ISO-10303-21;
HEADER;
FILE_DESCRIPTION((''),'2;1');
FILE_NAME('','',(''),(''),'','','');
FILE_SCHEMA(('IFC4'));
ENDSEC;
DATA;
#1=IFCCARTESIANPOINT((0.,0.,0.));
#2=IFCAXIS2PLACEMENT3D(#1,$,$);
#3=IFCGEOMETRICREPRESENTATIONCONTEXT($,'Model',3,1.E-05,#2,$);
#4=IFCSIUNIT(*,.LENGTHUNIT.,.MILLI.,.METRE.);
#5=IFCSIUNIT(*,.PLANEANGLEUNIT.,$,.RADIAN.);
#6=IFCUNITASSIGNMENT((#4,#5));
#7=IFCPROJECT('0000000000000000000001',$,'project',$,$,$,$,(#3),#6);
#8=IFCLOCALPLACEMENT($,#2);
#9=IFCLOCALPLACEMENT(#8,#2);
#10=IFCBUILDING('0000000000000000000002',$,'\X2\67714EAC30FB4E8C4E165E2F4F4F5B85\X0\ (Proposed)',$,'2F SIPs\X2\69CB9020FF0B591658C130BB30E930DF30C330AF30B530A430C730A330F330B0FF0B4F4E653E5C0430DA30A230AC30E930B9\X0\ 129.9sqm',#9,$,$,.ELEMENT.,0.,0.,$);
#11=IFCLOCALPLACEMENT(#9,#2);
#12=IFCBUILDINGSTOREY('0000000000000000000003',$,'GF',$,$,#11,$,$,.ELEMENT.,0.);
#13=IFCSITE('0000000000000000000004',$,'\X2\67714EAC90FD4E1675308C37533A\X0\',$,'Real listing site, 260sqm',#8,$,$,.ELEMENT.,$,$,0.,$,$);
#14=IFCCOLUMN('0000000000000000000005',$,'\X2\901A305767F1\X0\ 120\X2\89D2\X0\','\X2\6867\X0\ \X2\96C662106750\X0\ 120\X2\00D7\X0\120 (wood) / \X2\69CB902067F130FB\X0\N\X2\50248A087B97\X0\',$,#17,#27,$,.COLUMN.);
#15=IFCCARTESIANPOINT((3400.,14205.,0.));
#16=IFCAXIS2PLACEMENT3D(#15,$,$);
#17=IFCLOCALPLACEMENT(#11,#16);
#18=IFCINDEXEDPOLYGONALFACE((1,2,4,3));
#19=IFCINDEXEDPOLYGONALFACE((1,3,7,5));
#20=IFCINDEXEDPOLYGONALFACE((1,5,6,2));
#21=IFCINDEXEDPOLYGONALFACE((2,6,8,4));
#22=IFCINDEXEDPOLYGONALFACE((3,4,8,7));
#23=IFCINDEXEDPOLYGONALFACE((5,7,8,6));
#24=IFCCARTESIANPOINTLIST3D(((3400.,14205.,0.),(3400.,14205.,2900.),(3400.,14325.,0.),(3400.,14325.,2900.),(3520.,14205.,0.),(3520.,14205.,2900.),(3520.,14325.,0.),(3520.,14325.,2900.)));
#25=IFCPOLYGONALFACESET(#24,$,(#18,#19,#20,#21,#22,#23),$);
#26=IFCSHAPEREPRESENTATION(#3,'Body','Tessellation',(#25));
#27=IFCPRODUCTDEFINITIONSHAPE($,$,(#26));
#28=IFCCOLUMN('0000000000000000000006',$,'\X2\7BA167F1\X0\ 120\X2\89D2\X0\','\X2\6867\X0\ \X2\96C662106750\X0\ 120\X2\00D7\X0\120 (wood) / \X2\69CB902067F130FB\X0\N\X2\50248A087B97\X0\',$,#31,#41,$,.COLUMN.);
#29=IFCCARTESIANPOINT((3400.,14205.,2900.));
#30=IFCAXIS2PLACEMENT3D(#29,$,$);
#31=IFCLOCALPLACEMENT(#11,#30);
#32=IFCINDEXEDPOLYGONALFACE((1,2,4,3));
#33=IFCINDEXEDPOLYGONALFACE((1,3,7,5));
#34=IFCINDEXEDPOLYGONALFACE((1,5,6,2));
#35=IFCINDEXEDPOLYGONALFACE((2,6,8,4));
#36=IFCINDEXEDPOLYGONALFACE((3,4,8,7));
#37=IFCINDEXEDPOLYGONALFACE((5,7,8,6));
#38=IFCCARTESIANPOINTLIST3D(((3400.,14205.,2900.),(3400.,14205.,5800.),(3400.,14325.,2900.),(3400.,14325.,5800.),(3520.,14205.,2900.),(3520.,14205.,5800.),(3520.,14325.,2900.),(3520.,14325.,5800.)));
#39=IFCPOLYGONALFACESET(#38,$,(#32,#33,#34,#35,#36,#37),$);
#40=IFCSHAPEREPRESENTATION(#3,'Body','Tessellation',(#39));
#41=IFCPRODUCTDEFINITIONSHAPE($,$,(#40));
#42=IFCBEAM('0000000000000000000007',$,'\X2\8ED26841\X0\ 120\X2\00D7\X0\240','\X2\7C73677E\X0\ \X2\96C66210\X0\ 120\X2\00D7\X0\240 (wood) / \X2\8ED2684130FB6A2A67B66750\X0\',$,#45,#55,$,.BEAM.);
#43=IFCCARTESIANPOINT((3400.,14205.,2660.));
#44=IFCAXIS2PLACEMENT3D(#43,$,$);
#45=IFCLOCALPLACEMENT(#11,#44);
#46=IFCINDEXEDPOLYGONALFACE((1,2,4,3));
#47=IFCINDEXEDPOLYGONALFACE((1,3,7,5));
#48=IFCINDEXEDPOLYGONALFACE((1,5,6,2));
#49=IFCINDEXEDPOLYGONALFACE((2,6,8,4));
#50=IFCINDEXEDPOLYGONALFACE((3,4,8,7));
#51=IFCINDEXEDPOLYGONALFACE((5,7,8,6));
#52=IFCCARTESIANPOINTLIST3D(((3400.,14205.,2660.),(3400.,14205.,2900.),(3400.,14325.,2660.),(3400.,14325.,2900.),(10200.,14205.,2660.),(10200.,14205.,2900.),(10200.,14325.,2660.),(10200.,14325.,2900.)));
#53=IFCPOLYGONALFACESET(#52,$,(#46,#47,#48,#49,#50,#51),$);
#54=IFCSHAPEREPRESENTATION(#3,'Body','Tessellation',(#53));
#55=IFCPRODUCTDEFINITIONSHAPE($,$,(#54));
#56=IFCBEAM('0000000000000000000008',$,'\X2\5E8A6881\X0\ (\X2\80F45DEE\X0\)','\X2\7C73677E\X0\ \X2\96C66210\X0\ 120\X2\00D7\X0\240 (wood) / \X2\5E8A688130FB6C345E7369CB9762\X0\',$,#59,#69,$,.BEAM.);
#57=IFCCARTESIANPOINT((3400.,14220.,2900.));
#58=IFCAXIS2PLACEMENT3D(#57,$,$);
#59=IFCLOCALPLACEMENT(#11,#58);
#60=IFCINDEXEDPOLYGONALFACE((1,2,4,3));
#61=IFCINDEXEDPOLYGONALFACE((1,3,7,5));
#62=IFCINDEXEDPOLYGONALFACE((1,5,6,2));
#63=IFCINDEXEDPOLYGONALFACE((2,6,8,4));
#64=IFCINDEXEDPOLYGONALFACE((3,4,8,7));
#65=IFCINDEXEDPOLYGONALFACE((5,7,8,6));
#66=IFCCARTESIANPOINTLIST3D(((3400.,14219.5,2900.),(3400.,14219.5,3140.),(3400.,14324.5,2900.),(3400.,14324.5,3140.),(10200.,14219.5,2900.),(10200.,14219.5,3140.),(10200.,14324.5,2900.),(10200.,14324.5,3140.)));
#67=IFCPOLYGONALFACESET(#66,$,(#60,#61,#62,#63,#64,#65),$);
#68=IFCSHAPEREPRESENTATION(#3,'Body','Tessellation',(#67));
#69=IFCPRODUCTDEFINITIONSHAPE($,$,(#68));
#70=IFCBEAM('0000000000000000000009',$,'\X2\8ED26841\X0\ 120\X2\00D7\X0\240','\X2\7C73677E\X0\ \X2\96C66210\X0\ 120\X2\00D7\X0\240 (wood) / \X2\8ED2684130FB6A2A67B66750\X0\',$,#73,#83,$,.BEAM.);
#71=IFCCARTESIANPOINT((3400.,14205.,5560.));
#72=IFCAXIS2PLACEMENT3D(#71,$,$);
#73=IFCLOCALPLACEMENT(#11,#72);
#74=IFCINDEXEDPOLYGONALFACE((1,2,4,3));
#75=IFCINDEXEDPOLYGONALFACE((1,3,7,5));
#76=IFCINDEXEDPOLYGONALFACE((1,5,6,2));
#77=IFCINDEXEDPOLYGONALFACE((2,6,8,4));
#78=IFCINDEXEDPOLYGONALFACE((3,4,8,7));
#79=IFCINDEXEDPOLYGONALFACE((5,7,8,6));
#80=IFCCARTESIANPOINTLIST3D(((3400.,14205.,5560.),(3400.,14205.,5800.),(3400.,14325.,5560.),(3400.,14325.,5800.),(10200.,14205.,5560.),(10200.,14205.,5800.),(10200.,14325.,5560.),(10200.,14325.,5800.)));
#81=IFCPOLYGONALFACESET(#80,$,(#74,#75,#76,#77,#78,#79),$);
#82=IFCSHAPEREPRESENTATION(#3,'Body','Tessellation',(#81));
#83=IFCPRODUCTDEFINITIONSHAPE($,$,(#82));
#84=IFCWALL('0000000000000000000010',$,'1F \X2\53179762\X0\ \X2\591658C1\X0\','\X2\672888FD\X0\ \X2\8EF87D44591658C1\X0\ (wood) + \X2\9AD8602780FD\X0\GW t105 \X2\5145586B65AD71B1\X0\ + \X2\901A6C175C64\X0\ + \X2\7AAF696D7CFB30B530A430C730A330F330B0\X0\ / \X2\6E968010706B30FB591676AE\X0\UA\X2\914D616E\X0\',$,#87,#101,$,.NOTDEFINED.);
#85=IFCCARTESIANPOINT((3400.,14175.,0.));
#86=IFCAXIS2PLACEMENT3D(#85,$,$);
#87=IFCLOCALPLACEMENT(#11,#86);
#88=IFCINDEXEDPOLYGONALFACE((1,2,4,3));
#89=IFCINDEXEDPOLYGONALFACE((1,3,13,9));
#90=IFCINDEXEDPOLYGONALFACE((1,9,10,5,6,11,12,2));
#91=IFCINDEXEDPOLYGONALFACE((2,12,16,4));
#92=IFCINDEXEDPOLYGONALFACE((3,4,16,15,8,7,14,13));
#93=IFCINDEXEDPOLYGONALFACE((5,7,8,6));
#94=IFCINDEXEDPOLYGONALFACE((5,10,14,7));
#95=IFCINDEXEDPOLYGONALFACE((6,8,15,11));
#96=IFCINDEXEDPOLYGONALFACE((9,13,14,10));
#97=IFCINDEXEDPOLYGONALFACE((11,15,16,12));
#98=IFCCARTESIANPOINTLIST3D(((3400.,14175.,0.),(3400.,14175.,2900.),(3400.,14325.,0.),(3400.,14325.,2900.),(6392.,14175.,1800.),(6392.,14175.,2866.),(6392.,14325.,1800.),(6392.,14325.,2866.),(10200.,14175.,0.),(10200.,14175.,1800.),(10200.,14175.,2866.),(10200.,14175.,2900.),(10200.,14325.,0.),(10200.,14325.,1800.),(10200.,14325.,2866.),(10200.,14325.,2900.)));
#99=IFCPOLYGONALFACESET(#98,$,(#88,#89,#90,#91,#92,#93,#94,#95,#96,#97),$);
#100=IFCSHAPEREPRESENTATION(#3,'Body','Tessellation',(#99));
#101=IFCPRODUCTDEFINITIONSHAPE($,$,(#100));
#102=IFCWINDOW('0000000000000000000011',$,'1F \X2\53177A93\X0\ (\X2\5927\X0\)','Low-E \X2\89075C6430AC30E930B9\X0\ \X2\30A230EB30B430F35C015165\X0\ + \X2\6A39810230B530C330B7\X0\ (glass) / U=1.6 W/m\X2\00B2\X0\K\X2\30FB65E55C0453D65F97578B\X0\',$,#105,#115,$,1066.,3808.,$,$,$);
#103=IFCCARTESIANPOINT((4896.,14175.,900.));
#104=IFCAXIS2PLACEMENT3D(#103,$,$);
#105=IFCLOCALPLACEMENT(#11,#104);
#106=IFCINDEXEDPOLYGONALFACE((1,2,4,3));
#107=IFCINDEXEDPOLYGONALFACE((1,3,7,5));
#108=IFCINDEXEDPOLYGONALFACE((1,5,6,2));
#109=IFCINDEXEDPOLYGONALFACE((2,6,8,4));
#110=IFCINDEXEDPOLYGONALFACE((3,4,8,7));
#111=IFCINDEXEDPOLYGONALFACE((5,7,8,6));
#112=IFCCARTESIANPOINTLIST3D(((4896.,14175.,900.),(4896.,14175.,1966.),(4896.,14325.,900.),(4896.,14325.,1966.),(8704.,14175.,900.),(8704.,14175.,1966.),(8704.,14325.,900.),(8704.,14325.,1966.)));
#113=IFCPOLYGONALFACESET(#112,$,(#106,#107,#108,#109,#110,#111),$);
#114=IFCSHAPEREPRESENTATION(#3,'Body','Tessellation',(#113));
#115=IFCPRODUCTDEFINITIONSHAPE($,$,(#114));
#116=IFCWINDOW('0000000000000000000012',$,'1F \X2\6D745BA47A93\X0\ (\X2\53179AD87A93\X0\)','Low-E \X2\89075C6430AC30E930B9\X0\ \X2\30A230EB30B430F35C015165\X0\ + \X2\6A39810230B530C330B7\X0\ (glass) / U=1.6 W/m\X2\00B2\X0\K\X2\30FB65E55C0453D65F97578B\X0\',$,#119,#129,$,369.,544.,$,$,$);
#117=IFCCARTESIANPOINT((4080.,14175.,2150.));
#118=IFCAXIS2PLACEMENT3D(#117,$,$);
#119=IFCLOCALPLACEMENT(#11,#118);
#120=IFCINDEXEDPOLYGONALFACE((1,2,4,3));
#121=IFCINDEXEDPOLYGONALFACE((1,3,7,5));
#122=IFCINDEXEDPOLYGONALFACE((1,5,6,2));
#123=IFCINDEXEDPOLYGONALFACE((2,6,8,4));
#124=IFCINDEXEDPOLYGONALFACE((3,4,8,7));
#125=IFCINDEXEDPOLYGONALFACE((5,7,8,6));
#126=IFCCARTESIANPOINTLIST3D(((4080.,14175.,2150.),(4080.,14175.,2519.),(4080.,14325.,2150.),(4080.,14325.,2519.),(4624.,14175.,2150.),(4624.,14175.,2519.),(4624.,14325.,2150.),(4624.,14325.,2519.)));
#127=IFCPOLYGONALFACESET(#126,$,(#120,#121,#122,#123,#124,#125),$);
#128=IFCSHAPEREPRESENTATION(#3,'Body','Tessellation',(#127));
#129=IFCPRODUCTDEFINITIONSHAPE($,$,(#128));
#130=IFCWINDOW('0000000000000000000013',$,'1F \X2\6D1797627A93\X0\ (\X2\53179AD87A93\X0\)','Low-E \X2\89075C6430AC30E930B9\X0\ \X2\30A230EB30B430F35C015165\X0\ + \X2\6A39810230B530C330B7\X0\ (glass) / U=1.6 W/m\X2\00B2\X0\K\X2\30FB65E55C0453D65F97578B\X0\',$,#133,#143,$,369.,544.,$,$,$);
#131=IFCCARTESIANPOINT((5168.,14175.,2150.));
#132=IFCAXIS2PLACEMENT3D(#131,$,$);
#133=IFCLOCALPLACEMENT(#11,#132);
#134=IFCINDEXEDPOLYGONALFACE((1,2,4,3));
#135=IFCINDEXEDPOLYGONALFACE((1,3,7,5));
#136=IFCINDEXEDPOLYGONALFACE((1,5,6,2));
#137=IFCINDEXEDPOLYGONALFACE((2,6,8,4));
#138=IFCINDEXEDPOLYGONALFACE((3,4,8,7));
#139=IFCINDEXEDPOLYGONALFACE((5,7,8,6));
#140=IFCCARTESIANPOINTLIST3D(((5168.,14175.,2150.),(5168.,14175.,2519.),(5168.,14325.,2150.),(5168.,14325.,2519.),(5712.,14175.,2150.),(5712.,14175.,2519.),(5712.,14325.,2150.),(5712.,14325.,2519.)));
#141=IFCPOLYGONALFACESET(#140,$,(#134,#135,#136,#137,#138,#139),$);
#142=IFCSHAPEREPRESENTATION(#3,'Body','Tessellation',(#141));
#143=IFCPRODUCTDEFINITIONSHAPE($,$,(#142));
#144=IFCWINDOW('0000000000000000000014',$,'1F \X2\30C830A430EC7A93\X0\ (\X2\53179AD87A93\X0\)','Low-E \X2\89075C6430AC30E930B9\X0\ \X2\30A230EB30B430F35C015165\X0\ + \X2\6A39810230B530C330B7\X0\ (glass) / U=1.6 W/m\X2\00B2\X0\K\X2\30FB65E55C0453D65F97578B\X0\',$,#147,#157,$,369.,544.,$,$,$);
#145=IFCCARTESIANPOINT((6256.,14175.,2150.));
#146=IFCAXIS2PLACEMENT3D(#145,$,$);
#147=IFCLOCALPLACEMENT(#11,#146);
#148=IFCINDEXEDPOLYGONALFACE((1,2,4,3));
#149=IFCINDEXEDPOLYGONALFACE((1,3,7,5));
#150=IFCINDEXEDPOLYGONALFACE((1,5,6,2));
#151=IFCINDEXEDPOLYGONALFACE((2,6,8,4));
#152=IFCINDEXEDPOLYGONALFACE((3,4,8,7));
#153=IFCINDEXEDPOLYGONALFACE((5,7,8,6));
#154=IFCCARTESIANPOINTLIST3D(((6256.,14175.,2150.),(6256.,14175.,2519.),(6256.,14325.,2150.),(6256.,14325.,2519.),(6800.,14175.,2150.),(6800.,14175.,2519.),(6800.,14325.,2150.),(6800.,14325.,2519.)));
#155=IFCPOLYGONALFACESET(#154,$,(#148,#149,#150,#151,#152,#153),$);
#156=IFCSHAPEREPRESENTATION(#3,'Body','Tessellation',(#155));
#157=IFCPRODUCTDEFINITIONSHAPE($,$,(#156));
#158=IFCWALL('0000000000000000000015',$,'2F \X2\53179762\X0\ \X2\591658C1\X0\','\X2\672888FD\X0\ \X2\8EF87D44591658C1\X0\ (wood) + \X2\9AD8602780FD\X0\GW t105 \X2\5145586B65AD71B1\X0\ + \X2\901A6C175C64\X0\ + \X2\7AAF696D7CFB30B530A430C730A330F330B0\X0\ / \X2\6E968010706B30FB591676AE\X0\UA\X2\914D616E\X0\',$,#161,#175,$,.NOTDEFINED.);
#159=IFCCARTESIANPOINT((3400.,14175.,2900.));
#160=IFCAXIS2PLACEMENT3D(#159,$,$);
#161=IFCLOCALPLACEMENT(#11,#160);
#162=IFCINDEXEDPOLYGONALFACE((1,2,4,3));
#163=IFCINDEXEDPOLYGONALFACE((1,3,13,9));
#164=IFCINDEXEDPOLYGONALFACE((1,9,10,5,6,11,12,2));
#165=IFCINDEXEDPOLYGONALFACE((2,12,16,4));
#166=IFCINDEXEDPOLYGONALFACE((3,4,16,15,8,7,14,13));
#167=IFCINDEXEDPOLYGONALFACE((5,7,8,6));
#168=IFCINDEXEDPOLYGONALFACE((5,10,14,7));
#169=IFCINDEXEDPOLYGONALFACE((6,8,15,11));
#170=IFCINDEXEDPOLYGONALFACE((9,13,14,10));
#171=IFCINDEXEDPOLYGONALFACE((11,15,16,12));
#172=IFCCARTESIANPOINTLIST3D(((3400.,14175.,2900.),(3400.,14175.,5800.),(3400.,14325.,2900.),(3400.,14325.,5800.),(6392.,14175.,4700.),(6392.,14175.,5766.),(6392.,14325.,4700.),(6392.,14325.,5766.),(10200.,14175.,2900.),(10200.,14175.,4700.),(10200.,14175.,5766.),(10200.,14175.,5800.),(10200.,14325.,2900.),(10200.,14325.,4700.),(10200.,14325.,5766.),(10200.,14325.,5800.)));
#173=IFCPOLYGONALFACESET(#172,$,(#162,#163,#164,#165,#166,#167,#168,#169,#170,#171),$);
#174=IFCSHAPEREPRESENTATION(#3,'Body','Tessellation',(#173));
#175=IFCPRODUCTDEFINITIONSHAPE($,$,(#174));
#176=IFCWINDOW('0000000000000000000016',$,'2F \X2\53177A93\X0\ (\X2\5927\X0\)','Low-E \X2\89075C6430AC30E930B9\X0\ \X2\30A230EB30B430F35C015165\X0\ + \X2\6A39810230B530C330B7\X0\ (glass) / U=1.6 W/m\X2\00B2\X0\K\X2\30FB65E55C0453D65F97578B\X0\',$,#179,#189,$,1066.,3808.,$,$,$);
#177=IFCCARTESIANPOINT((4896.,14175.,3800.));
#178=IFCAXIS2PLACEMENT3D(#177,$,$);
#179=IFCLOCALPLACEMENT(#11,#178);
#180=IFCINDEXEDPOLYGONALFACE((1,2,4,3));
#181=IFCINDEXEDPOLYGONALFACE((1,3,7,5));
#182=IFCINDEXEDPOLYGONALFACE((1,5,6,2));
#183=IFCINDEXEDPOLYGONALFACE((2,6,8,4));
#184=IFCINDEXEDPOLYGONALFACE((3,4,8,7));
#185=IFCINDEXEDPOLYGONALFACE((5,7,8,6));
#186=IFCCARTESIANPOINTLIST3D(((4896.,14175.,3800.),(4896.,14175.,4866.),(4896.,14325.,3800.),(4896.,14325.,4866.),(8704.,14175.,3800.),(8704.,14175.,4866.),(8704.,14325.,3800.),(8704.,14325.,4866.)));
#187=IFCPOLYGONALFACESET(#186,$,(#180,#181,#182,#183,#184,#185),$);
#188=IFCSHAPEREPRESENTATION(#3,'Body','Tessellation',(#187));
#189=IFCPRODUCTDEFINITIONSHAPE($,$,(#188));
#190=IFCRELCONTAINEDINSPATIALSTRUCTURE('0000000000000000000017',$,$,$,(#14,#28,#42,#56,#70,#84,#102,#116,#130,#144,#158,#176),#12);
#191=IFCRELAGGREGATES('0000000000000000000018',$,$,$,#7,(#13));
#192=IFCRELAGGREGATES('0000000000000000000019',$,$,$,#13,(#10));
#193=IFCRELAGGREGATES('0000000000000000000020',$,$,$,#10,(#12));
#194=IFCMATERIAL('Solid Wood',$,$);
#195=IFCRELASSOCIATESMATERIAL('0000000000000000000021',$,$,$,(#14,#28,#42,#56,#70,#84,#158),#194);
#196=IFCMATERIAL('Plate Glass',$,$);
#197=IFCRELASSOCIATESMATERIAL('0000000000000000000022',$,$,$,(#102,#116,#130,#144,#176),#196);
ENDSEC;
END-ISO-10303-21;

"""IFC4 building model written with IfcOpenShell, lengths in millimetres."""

from ifc_helpers import new_model, si_unit, frame, frame_2d, origin, place, context, project, spatial, rectangle, extrude, material, element, fill, save


model = new_model("IFC4")

# Units and contexts
model_context = context("Model", 3, precision=1e-05, world=origin())
ifc_project = project(units=[si_unit("LENGTHUNIT", "METRE", prefix="MILLI"), si_unit("PLANEANGLEUNIT", "RADIAN")], contexts=[model_context])

# Site, building, storey
site_placement = place(None, origin())
site = spatial("IfcSite", under=ifc_project, at=site_placement, Name="東京都世田谷区", ObjectType="Real listing site, 260sqm", CompositionType="ELEMENT", RefElevation=0.0)
building_placement = place(site_placement, origin())
building = spatial("IfcBuilding", under=site, at=building_placement, Name="東京・二世帯住宅 (Proposed)", ObjectType="2F SIPs構造＋外壁セラミックサイディング＋低放射ペアガラス 129.9sqm", CompositionType="ELEMENT", ElevationOfRefHeight=0.0, ElevationOfTerrain=0.0)
storey_placement = place(building_placement, origin())
storey = spatial("IfcBuildingStorey", under=building, at=storey_placement, Name="GF", CompositionType="ELEMENT", Elevation=0.0)

# Columns
ifc_material_1 = material(Name="Solid Wood")
column_1_placement = place(storey_placement, frame((3400.0, 14205.0, 0.0)))
element("IfcColumn", 1, at=column_1_placement, inside=storey, material=ifc_material_1, Name="通し柱 120角", Description="桧 集成材 120×120 (wood) / 構造柱・N値計算", PredefinedType="COLUMN", context=model_context, shape_type="SweptSolid", body=[
    extrude(rectangle(XDim=120.0, YDim=120.0, at=frame_2d((60.0, 60.0))), frame((3400.0, 14205.0, 0.0)), (0.0, 0.0, 1.0), 2900.0),
])
column_2_placement = place(storey_placement, frame((3400.0, 14205.0, 2900.0)))
element("IfcColumn", 2, at=column_2_placement, inside=storey, material=ifc_material_1, Name="管柱 120角", Description="桧 集成材 120×120 (wood) / 構造柱・N値計算", PredefinedType="COLUMN", context=model_context, shape_type="SweptSolid", body=[
    extrude(rectangle(XDim=120.0, YDim=120.0, at=frame_2d((60.0, 60.0))), frame((3400.0, 14205.0, 2900.0)), (0.0, 0.0, 1.0), 2900.0),
])

# Beams
beam_1_placement = place(storey_placement, frame((3400.0, 14205.0, 2660.0)))
element("IfcBeam", 3, at=beam_1_placement, inside=storey, material=ifc_material_1, Name="軒桁 120×240", Description="米松 集成 120×240 (wood) / 軒桁・横架材", PredefinedType="BEAM", context=model_context, shape_type="SweptSolid", body=[
    extrude(rectangle(XDim=6800.0, YDim=120.0, at=frame_2d((3400.0, 60.0))), frame((3400.0, 14205.0, 2660.0)), (0.0, 0.0, 1.0), 240.0),
])
beam_2_placement = place(storey_placement, frame((3400.0, 14220.0, 2900.0)))
element("IfcBeam", 4, at=beam_2_placement, inside=storey, material=ifc_material_1, Name="床梁 (胴差)", Description="米松 集成 120×240 (wood) / 床梁・水平構面", PredefinedType="BEAM", context=model_context, shape_type="SweptSolid", body=[
    extrude(rectangle(XDim=6800.0, YDim=105.0, at=frame_2d((3400.0, 52.0))), frame((3400.0, 14220.0, 2900.0)), (0.0, 0.0, 1.0), 240.0),
])
beam_3_placement = place(storey_placement, frame((3400.0, 14205.0, 5560.0)))
element("IfcBeam", 5, at=beam_3_placement, inside=storey, material=ifc_material_1, Name="軒桁 120×240", Description="米松 集成 120×240 (wood) / 軒桁・横架材", PredefinedType="BEAM", context=model_context, shape_type="SweptSolid", body=[
    extrude(rectangle(XDim=6800.0, YDim=120.0, at=frame_2d((3400.0, 60.0))), frame((3400.0, 14205.0, 5560.0)), (0.0, 0.0, 1.0), 240.0),
])

# Wall, openings, windows
wall_1_placement = place(storey_placement, frame((3400.0, 14175.0, 0.0)))
wall_1 = element("IfcWall", 6, at=wall_1_placement, inside=storey, material=ifc_material_1, Name="1F 北面 外壁", Description="木製 軸組外壁 (wood) + 高性能GW t105 充填断熱 + 通気層 + 窯業系サイディング / 準耐火・外皮UA配慮", PredefinedType="NOTDEFINED", context=model_context, shape_type="SweptSolid", body=[
    extrude(rectangle(XDim=6800.0, YDim=150.0, at=frame_2d((3400.0, 75.0))), frame((3400.0, 14175.0, 0.0)), (0.0, 0.0, 1.0), 2900.0),
])
opening_1_placement = place(storey_placement, frame((4896.0, 14175.0, 900.0)))
opening_1 = element("IfcOpeningElement", 7, at=opening_1_placement, cuts=wall_1, PredefinedType="NOTDEFINED", context=model_context, shape_type="SweptSolid", body=[
    extrude(rectangle(XDim=3808.0, YDim=150.0, at=frame_2d((1904.0, 75.0))), frame((4896.0, 14175.0, 900.0)), (0.0, 0.0, 1.0), 1066.0),
])
opening_2_placement = place(storey_placement, frame((4080.0, 14175.0, 2150.0)))
opening_2 = element("IfcOpeningElement", 8, at=opening_2_placement, cuts=wall_1, PredefinedType="NOTDEFINED", context=model_context, shape_type="SweptSolid", body=[
    extrude(rectangle(XDim=544.0, YDim=150.0, at=frame_2d((272.0, 75.0))), frame((4080.0, 14175.0, 2150.0)), (0.0, 0.0, 1.0), 369.0),
])
opening_3_placement = place(storey_placement, frame((5168.0, 14175.0, 2150.0)))
opening_3 = element("IfcOpeningElement", 9, at=opening_3_placement, cuts=wall_1, PredefinedType="NOTDEFINED", context=model_context, shape_type="SweptSolid", body=[
    extrude(rectangle(XDim=544.0, YDim=150.0, at=frame_2d((272.0, 75.0))), frame((5168.0, 14175.0, 2150.0)), (0.0, 0.0, 1.0), 369.0),
])
opening_4_placement = place(storey_placement, frame((6256.0, 14175.0, 2150.0)))
opening_4 = element("IfcOpeningElement", 10, at=opening_4_placement, cuts=wall_1, PredefinedType="NOTDEFINED", context=model_context, shape_type="SweptSolid", body=[
    extrude(rectangle(XDim=544.0, YDim=150.0, at=frame_2d((272.0, 75.0))), frame((6256.0, 14175.0, 2150.0)), (0.0, 0.0, 1.0), 369.0),
])
ifc_material_2 = material(Name="Plate Glass")
window_1_placement = place(storey_placement, frame((4896.0, 14175.0, 900.0)))
window_1 = element("IfcWindow", 11, at=window_1_placement, inside=storey, material=ifc_material_2, Name="1F 北窓 (大)", Description="Low-E 複層ガラス アルゴン封入 + 樹脂サッシ (glass) / U=1.6 W/m²K・日射取得型", OverallHeight=1066.0, OverallWidth=3808.0, context=model_context, shape_type="SweptSolid", body=[
    extrude(rectangle(XDim=3808.0, YDim=150.0, at=frame_2d((1904.0, 75.0))), frame((4896.0, 14175.0, 900.0)), (0.0, 0.0, 1.0), 1066.0),
])
fill(opening_1, window_1)
window_2_placement = place(storey_placement, frame((4080.0, 14175.0, 2150.0)))
window_2 = element("IfcWindow", 12, at=window_2_placement, inside=storey, material=ifc_material_2, Name="1F 浴室窓 (北高窓)", Description="Low-E 複層ガラス アルゴン封入 + 樹脂サッシ (glass) / U=1.6 W/m²K・日射取得型", OverallHeight=369.0, OverallWidth=544.0, context=model_context, shape_type="SweptSolid", body=[
    extrude(rectangle(XDim=544.0, YDim=150.0, at=frame_2d((272.0, 75.0))), frame((4080.0, 14175.0, 2150.0)), (0.0, 0.0, 1.0), 369.0),
])
fill(opening_2, window_2)
window_3_placement = place(storey_placement, frame((5168.0, 14175.0, 2150.0)))
window_3 = element("IfcWindow", 13, at=window_3_placement, inside=storey, material=ifc_material_2, Name="1F 洗面窓 (北高窓)", Description="Low-E 複層ガラス アルゴン封入 + 樹脂サッシ (glass) / U=1.6 W/m²K・日射取得型", OverallHeight=369.0, OverallWidth=544.0, context=model_context, shape_type="SweptSolid", body=[
    extrude(rectangle(XDim=544.0, YDim=150.0, at=frame_2d((272.0, 75.0))), frame((5168.0, 14175.0, 2150.0)), (0.0, 0.0, 1.0), 369.0),
])
fill(opening_3, window_3)
window_4_placement = place(storey_placement, frame((6256.0, 14175.0, 2150.0)))
window_4 = element("IfcWindow", 14, at=window_4_placement, inside=storey, material=ifc_material_2, Name="1F トイレ窓 (北高窓)", Description="Low-E 複層ガラス アルゴン封入 + 樹脂サッシ (glass) / U=1.6 W/m²K・日射取得型", OverallHeight=369.0, OverallWidth=544.0, context=model_context, shape_type="SweptSolid", body=[
    extrude(rectangle(XDim=544.0, YDim=150.0, at=frame_2d((272.0, 75.0))), frame((6256.0, 14175.0, 2150.0)), (0.0, 0.0, 1.0), 369.0),
])
fill(opening_4, window_4)

# Wall, opening, window
wall_2_placement = place(storey_placement, frame((3400.0, 14175.0, 2900.0)))
wall_2 = element("IfcWall", 15, at=wall_2_placement, inside=storey, material=ifc_material_1, Name="2F 北面 外壁", Description="木製 軸組外壁 (wood) + 高性能GW t105 充填断熱 + 通気層 + 窯業系サイディング / 準耐火・外皮UA配慮", PredefinedType="NOTDEFINED", context=model_context, shape_type="SweptSolid", body=[
    extrude(rectangle(XDim=6800.0, YDim=150.0, at=frame_2d((3400.0, 75.0))), frame((3400.0, 14175.0, 2900.0)), (0.0, 0.0, 1.0), 2900.0),
])
opening_5_placement = place(storey_placement, frame((4896.0, 14175.0, 3800.0)))
opening_5 = element("IfcOpeningElement", 16, at=opening_5_placement, cuts=wall_2, PredefinedType="NOTDEFINED", context=model_context, shape_type="SweptSolid", body=[
    extrude(rectangle(XDim=3808.0, YDim=150.0, at=frame_2d((1904.0, 75.0))), frame((4896.0, 14175.0, 3800.0)), (0.0, 0.0, 1.0), 1066.0),
])
window_5_placement = place(storey_placement, frame((4896.0, 14175.0, 3800.0)))
window_5 = element("IfcWindow", 17, at=window_5_placement, inside=storey, material=ifc_material_2, Name="2F 北窓 (大)", Description="Low-E 複層ガラス アルゴン封入 + 樹脂サッシ (glass) / U=1.6 W/m²K・日射取得型", OverallHeight=1066.0, OverallWidth=3808.0, context=model_context, shape_type="SweptSolid", body=[
    extrude(rectangle(XDim=3808.0, YDim=150.0, at=frame_2d((1904.0, 75.0))), frame((4896.0, 14175.0, 3800.0)), (0.0, 0.0, 1.0), 1066.0),
])
fill(opening_5, window_5)

save(model, "model.ifc")
